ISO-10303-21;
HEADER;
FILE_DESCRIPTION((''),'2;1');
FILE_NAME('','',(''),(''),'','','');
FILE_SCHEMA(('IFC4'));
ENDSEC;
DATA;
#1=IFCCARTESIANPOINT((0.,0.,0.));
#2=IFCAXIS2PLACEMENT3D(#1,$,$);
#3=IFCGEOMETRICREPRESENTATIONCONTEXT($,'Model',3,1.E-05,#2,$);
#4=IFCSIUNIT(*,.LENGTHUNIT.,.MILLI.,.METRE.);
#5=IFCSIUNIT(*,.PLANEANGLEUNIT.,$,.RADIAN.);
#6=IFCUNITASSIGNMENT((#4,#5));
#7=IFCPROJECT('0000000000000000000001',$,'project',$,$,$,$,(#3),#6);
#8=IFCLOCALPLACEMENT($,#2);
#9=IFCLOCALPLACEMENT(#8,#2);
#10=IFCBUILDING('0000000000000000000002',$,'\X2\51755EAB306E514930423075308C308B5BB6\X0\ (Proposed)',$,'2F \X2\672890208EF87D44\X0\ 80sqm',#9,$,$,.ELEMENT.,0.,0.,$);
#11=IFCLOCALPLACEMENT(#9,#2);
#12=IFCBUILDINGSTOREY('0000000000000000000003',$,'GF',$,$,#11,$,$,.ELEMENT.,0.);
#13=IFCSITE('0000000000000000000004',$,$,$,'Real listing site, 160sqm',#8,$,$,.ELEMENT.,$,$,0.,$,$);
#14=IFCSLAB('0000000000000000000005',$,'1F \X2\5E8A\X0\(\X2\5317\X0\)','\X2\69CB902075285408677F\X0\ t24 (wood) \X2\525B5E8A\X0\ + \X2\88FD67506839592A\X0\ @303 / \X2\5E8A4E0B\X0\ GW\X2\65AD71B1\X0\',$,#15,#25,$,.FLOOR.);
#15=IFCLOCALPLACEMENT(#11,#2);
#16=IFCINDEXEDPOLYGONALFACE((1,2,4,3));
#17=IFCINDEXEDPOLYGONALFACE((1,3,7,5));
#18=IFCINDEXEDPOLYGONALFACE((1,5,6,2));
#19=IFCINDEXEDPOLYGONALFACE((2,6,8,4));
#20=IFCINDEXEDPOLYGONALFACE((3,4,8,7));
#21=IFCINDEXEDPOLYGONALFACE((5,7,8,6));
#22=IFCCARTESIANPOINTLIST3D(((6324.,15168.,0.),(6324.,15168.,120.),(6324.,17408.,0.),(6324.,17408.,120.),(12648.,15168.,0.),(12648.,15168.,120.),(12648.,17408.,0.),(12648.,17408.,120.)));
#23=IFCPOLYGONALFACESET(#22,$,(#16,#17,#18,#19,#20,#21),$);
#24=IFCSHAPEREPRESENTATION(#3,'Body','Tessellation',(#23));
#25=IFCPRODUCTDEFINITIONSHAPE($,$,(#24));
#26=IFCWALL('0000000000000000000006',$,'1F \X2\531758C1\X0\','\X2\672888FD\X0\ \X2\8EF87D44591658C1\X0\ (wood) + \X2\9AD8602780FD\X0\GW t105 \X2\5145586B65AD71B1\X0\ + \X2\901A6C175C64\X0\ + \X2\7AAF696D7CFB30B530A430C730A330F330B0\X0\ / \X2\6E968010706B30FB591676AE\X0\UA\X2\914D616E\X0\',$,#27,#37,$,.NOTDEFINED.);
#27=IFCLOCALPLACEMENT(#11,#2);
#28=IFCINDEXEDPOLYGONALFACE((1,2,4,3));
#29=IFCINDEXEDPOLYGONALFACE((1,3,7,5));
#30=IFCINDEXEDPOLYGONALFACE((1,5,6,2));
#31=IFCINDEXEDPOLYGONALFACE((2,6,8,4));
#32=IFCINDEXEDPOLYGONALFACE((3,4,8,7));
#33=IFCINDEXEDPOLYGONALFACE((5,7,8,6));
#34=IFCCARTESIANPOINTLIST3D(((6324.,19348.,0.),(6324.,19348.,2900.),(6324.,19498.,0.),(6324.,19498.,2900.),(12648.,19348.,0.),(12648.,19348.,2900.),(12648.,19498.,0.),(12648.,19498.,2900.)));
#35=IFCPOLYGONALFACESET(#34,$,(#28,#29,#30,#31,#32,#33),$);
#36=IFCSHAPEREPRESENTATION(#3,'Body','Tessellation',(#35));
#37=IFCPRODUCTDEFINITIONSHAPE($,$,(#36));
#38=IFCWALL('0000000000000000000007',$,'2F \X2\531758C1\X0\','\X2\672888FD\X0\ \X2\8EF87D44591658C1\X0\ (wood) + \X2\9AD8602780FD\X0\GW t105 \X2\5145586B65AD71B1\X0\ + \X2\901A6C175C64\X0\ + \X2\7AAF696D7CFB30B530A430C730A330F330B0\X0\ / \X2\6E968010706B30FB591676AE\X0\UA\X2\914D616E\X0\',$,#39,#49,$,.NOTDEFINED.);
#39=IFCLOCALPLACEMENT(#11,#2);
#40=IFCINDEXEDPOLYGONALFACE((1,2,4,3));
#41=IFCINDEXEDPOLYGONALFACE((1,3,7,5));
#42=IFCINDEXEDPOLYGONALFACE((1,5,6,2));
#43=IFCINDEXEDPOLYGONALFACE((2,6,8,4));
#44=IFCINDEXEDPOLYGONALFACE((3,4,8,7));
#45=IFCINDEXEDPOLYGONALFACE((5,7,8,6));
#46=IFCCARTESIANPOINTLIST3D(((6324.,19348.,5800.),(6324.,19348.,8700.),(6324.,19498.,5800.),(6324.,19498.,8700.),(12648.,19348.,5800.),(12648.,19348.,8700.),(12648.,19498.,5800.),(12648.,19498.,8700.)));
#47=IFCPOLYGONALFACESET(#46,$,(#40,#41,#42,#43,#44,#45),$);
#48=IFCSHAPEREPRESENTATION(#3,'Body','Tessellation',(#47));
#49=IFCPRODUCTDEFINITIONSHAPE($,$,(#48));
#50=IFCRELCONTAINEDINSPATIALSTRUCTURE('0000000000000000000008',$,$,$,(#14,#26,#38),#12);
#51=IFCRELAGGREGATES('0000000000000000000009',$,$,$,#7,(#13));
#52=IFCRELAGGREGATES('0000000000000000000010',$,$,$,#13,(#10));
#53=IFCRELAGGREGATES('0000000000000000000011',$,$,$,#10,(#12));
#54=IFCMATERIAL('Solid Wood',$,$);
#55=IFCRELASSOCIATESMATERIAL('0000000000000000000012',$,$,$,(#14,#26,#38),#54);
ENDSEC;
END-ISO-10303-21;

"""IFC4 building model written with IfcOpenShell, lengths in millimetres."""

from ifc_helpers import new_model, si_unit, frame, frame_2d, origin, place, context, project, spatial, rectangle, extrude, material, element, save


model = new_model("IFC4")

# Units and contexts
model_context = context("Model", 3, precision=1e-05, world=origin())
ifc_project = project(units=[si_unit("LENGTHUNIT", "METRE", prefix="MILLI"), si_unit("PLANEANGLEUNIT", "RADIAN")], contexts=[model_context])

# Site, building, storey
site_placement = place(None, origin())
site = spatial("IfcSite", under=ifc_project, at=site_placement, ObjectType="Real listing site, 160sqm", CompositionType="ELEMENT", RefElevation=0.0)
building_placement = place(site_placement, origin())
building = spatial("IfcBuilding", under=site, at=building_placement, Name="兵庫の光あふれる家 (Proposed)", ObjectType="2F 木造軸組 80sqm", CompositionType="ELEMENT", ElevationOfRefHeight=0.0, ElevationOfTerrain=0.0)
storey_placement = place(building_placement, origin())
storey = spatial("IfcBuildingStorey", under=building, at=storey_placement, Name="GF", CompositionType="ELEMENT", Elevation=0.0)

# Slab
ifc_material_1 = material(Name="Solid Wood")
slab_1_placement = place(storey_placement, frame((3162.0, 7584.0, 0.0)))
element("IfcSlab", 1, at=slab_1_placement, inside=storey, material=ifc_material_1, Name="1F 床(北)", Description="構造用合板 t24 (wood) 剛床 + 製材根太 @303 / 床下 GW断熱", PredefinedType="FLOOR", context=model_context, shape_type="SweptSolid", body=[
    extrude(rectangle(XDim=6324.0, YDim=2240.0, at=frame_2d((3162.0, 1120.0))), frame((3162.0, 7584.0, 0.0)), (0.0, 0.0, 1.0), 120.0),
])

# Wall
wall_1_placement = place(storey_placement, frame((3162.0, 9674.0, 0.0)))
element("IfcWall", 2, at=wall_1_placement, inside=storey, material=ifc_material_1, Name="1F 北壁", Description="木製 軸組外壁 (wood) + 高性能GW t105 充填断熱 + 通気層 + 窯業系サイディング / 準耐火・外皮UA配慮", PredefinedType="NOTDEFINED", context=model_context, shape_type="SweptSolid", body=[
    extrude(rectangle(XDim=6324.0, YDim=150.0, at=frame_2d((3162.0, 75.0))), frame((3162.0, 9674.0, 0.0)), (0.0, 0.0, 1.0), 2900.0),
])

# Wall
wall_2_placement = place(storey_placement, frame((3162.0, 9674.0, 2900.0)))
element("IfcWall", 3, at=wall_2_placement, inside=storey, material=ifc_material_1, Name="2F 北壁", Description="木製 軸組外壁 (wood) + 高性能GW t105 充填断熱 + 通気層 + 窯業系サイディング / 準耐火・外皮UA配慮", PredefinedType="NOTDEFINED", context=model_context, shape_type="SweptSolid", body=[
    extrude(rectangle(XDim=6324.0, YDim=150.0, at=frame_2d((3162.0, 75.0))), frame((3162.0, 9674.0, 2900.0)), (0.0, 0.0, 1.0), 2900.0),
])

save(model, "model.ifc")
